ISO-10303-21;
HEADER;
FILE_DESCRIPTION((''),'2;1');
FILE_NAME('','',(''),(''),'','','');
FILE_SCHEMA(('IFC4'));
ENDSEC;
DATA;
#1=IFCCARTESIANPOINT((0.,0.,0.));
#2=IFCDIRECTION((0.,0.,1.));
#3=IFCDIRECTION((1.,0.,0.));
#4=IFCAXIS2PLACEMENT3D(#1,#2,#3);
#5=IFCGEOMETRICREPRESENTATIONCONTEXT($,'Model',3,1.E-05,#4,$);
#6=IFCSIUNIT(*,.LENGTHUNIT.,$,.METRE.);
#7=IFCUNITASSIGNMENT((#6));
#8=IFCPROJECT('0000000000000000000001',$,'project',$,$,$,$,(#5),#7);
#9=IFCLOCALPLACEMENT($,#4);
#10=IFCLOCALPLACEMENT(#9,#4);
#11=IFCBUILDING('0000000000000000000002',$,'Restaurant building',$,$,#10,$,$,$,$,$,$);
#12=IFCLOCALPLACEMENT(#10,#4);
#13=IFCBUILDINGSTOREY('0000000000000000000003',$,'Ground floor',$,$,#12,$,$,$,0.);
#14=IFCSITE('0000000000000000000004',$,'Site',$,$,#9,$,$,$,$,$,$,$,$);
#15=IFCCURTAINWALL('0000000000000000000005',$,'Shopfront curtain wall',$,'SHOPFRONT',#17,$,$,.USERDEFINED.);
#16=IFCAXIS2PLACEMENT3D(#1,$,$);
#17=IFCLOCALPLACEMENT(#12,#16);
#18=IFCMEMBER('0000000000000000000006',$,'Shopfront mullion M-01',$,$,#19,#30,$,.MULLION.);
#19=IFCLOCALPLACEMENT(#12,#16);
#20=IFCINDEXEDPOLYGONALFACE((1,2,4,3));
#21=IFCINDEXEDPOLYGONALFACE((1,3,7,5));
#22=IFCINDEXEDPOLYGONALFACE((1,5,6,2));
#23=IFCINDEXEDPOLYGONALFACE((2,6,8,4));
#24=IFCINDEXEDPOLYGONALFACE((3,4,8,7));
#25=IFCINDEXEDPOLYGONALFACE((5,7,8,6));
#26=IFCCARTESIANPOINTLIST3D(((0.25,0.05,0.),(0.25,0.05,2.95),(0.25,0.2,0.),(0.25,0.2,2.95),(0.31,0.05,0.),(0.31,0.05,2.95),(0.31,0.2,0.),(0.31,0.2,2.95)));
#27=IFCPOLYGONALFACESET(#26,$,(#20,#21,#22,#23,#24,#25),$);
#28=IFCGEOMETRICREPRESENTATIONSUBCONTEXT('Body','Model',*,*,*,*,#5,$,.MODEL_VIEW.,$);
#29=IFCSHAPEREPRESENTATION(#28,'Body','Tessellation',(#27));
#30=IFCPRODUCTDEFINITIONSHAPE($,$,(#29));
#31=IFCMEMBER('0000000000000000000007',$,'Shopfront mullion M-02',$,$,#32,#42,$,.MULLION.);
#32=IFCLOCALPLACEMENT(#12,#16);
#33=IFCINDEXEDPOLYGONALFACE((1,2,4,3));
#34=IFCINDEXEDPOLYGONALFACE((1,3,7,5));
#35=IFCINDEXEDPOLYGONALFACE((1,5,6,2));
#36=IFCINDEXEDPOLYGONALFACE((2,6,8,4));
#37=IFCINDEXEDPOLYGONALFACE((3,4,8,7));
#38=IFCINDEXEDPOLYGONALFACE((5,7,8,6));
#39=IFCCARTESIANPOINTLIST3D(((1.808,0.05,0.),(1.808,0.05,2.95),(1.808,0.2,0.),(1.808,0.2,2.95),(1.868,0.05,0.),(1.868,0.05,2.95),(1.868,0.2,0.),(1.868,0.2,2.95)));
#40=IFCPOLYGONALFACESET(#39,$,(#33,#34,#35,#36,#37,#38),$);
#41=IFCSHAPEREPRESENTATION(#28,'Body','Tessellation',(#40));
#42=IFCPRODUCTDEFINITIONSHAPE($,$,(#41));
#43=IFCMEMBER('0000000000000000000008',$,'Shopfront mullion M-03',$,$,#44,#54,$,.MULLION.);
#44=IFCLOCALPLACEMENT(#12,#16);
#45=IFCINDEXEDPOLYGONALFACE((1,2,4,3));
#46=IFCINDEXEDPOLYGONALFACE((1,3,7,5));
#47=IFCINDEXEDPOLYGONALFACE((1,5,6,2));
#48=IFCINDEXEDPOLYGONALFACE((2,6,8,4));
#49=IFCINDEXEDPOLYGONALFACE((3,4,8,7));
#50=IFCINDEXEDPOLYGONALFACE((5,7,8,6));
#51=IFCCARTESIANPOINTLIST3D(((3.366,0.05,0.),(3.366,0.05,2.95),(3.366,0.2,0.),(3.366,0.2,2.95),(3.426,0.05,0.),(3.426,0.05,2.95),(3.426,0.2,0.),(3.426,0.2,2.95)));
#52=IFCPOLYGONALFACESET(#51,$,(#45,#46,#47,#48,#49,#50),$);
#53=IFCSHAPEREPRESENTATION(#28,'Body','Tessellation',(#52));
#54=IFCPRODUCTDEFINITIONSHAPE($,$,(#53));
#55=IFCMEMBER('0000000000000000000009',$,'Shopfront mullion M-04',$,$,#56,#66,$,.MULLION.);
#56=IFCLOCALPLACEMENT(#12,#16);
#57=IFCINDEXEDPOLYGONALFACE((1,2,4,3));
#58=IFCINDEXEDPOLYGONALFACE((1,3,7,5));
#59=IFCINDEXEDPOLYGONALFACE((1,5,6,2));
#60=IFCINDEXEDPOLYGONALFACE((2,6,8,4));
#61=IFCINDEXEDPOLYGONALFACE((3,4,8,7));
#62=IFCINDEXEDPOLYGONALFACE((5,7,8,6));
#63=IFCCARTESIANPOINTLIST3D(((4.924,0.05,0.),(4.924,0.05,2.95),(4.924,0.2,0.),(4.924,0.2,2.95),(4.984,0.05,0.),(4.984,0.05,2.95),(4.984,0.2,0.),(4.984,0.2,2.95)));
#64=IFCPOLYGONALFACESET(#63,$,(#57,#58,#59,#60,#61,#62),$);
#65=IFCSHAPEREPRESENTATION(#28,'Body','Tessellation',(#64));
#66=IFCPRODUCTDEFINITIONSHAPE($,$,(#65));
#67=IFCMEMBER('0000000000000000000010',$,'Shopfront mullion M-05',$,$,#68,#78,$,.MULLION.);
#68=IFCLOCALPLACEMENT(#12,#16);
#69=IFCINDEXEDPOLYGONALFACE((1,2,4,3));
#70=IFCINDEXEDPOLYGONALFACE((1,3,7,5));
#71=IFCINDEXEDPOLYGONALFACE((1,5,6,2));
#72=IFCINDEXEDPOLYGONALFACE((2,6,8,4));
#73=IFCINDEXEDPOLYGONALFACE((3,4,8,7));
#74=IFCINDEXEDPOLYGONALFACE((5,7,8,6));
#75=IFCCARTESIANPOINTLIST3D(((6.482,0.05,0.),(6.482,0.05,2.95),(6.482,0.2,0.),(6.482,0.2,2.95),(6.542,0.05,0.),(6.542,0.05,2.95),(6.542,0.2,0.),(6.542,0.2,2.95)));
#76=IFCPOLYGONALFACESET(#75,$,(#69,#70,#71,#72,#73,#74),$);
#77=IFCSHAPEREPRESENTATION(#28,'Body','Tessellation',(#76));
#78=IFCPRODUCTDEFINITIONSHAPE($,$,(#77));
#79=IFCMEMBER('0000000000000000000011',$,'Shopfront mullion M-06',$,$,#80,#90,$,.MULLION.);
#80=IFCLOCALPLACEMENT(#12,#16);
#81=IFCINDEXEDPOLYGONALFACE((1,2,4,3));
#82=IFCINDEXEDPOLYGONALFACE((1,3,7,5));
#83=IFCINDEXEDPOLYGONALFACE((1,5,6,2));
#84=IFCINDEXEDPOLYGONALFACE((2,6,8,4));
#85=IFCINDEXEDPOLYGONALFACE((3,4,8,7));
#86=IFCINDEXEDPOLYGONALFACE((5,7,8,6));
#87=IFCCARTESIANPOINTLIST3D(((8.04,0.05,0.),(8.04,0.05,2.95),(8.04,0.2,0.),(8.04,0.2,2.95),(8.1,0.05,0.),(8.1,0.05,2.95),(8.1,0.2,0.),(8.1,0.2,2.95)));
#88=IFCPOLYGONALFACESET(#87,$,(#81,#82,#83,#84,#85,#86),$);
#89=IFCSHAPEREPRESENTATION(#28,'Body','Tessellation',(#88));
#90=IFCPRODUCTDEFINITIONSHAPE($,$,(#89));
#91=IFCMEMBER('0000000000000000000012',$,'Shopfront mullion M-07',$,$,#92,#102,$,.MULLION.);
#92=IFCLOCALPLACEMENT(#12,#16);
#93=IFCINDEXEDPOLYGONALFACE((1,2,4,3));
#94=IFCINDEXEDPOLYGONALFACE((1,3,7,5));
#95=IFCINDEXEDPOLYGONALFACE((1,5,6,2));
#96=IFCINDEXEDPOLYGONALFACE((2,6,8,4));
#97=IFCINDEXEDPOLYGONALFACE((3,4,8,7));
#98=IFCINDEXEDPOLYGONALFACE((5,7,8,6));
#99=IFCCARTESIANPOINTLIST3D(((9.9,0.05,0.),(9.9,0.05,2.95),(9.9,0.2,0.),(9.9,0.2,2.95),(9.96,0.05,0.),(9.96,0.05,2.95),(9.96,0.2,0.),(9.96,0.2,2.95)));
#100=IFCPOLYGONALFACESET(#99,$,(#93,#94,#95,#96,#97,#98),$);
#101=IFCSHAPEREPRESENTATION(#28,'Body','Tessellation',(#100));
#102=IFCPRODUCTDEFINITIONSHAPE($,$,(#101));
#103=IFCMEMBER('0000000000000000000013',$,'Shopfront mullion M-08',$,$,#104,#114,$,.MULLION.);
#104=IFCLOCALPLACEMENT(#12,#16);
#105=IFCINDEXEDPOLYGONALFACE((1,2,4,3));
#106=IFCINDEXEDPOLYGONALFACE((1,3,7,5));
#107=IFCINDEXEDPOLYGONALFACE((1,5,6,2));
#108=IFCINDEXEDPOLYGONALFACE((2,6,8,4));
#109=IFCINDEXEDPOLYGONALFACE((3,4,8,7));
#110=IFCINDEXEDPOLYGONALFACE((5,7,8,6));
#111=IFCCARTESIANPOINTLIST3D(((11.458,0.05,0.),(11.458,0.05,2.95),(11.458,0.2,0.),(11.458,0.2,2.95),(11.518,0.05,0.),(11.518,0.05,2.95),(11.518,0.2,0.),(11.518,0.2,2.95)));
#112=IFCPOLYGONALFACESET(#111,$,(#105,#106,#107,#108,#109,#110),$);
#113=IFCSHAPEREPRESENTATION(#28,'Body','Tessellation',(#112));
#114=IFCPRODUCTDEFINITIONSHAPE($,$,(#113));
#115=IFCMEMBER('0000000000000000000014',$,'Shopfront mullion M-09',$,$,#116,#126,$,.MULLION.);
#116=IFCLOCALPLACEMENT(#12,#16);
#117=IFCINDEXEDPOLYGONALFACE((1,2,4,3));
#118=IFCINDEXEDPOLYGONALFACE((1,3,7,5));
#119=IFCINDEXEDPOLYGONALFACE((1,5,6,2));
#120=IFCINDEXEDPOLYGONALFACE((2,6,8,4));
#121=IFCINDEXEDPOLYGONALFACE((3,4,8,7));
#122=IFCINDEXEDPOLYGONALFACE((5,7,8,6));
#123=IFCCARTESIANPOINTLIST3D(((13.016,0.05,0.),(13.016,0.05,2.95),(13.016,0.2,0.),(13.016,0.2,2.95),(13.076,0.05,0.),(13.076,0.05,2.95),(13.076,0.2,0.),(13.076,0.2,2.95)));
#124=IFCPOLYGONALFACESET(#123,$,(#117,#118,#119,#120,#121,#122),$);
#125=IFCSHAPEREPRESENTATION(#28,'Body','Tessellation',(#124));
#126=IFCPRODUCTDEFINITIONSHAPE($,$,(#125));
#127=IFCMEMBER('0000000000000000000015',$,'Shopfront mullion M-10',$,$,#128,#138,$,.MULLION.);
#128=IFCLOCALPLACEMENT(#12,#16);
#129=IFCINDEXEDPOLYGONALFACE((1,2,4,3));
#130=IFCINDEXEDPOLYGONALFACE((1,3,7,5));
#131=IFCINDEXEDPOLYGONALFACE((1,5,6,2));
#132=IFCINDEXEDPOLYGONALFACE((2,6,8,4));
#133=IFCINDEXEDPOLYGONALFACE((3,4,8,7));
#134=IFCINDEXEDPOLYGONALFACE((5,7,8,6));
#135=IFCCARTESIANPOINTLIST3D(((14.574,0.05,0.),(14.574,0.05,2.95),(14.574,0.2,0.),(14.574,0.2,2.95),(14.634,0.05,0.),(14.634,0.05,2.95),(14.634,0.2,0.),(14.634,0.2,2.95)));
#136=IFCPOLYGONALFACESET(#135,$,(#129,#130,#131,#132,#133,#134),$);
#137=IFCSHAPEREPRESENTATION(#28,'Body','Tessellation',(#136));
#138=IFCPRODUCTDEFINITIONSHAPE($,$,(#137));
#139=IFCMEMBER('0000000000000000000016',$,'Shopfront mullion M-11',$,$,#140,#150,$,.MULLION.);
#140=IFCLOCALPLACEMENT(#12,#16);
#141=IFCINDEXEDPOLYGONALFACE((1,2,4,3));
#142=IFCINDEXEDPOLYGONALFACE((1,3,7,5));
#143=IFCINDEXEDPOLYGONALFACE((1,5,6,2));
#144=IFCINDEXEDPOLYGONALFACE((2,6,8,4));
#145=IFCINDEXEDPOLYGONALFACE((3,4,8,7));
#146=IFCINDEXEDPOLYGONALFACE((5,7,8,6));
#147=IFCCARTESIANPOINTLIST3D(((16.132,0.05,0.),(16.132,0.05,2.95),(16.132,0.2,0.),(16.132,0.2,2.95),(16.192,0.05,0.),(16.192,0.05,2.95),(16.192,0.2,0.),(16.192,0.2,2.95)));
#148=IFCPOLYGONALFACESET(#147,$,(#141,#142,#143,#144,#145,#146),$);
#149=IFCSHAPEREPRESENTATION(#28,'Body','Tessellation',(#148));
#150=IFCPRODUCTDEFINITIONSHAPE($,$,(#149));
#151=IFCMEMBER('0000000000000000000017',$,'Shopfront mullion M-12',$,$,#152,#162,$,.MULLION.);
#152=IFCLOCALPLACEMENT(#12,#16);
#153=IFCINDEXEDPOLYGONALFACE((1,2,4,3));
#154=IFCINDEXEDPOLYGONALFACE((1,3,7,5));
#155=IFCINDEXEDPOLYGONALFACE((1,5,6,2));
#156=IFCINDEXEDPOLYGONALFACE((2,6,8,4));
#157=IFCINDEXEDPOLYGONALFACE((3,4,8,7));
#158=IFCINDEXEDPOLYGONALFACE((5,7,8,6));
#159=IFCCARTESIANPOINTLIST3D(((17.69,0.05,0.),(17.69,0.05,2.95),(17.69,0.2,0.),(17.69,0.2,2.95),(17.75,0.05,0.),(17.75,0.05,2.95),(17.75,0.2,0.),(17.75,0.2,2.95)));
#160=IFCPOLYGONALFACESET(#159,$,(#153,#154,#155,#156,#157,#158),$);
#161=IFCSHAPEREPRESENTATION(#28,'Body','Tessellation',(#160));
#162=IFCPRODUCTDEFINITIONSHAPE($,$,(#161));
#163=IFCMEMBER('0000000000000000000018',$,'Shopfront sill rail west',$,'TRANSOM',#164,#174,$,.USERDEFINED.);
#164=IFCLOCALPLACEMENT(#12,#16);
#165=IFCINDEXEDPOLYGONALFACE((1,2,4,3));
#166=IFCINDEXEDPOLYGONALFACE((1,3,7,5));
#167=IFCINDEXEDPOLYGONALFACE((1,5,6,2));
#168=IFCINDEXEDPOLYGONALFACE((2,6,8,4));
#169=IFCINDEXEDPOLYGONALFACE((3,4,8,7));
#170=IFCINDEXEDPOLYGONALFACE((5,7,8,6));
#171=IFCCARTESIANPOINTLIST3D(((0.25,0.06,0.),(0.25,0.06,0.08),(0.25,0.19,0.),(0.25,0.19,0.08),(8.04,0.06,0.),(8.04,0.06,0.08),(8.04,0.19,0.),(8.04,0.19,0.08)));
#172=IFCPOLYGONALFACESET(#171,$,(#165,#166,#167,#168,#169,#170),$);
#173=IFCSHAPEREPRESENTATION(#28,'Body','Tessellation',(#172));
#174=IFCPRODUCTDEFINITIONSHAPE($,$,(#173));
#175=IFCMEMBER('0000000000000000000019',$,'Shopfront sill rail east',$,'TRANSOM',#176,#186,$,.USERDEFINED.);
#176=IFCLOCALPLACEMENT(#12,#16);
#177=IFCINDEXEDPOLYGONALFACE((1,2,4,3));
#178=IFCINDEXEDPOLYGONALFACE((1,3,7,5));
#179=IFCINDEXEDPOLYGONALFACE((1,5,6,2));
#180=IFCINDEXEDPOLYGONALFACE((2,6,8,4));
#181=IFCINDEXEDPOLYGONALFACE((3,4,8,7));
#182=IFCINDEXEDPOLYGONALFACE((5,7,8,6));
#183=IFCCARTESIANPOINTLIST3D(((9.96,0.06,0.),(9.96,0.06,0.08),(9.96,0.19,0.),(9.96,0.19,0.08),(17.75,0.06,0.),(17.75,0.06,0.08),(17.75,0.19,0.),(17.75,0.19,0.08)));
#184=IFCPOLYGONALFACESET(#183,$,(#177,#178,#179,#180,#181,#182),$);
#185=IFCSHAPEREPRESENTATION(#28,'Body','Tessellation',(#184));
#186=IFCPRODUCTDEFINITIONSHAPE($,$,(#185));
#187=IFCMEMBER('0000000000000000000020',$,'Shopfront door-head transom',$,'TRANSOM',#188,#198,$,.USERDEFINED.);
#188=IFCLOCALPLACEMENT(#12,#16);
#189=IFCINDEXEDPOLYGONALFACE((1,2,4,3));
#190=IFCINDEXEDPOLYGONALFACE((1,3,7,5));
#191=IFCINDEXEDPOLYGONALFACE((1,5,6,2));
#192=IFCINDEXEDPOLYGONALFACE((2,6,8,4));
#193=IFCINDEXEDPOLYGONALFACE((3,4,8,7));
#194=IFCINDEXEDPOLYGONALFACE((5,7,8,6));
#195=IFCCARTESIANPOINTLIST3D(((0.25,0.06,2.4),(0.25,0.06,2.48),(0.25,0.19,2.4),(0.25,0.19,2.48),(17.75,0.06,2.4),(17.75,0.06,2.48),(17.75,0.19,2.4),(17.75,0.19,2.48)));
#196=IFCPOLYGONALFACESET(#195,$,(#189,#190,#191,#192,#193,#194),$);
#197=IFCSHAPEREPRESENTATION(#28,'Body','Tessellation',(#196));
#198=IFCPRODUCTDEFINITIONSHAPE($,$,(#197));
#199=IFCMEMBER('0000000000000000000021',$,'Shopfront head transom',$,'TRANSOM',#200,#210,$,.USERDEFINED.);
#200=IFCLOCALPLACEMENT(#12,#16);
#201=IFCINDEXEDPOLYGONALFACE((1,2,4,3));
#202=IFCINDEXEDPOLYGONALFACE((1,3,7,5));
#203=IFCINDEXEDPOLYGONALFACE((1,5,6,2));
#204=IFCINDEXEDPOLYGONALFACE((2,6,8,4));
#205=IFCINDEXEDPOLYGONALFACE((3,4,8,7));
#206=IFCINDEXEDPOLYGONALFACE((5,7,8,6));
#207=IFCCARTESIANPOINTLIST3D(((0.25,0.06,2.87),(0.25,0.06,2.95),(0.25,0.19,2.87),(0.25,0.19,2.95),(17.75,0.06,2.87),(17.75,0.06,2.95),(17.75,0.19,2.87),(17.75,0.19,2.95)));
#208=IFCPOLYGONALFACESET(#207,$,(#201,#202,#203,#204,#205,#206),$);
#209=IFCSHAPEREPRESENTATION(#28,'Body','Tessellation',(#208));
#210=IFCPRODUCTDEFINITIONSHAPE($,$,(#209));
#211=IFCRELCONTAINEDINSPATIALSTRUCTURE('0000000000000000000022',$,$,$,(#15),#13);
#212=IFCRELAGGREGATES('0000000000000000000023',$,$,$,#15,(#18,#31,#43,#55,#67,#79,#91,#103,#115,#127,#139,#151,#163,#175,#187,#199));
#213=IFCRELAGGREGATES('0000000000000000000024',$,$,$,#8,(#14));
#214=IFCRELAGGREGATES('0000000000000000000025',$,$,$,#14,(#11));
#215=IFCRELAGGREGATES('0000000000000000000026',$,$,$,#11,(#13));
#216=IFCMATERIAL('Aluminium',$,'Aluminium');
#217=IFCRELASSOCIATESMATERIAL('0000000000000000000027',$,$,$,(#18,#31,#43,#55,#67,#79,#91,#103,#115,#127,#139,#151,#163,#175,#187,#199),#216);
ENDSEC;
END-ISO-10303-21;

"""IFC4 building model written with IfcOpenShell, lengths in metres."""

from ifc_helpers import new_model, si_unit, frame, origin, origin_with_axes, origin_2d, place, context, subcontext, project, spatial, rectangle, extrude, material, element, aggregate, save


model = new_model("IFC4")

# Units and contexts
model_context = context("Model", 3, precision=1e-05, world=origin_with_axes())
body_context = subcontext(model_context, "Body", "Model", "MODEL_VIEW")
ifc_project = project(units=[si_unit("LENGTHUNIT", "METRE")], contexts=[model_context])

# Site, building, storey
site_placement = place(None, origin_with_axes())
site = spatial("IfcSite", under=ifc_project, at=site_placement, Name="Site")
building_placement = place(site_placement, origin_with_axes())
building = spatial("IfcBuilding", under=site, at=building_placement, Name="Restaurant building")
storey_placement = place(building_placement, origin_with_axes())
storey = spatial("IfcBuildingStorey", under=building, at=storey_placement, Name="Ground floor", Elevation=0.0)

# Curtain wall, members
curtain_wall_placement = place(storey_placement, origin())
curtain_wall = element("IfcCurtainWall", 1, at=curtain_wall_placement, inside=storey, Name="Shopfront curtain wall", ObjectType="SHOPFRONT", PredefinedType="USERDEFINED")
ifc_material_1 = material(Name="Aluminium", Category="Aluminium")
member_1_placement = place(curtain_wall_placement, origin_with_axes())
member_1 = element("IfcMember", 2, at=member_1_placement, material=ifc_material_1, Name="Shopfront mullion M-01", PredefinedType="MULLION", context=body_context, shape_type="SweptSolid", body=[
    extrude(rectangle(XDim=0.06, YDim=0.15, at=origin_2d()), frame((0.28, 0.125, 0.0)), (0.0, 0.0, 1.0), 2.95),
])
member_2_placement = place(curtain_wall_placement, origin_with_axes())
member_2 = element("IfcMember", 3, at=member_2_placement, material=ifc_material_1, Name="Shopfront mullion M-02", PredefinedType="MULLION", context=body_context, shape_type="SweptSolid", body=[
    extrude(rectangle(XDim=0.06, YDim=0.15, at=origin_2d()), frame((1.838, 0.125, 0.0)), (0.0, 0.0, 1.0), 2.95),
])
member_3_placement = place(curtain_wall_placement, origin_with_axes())
member_3 = element("IfcMember", 4, at=member_3_placement, material=ifc_material_1, Name="Shopfront mullion M-03", PredefinedType="MULLION", context=body_context, shape_type="SweptSolid", body=[
    extrude(rectangle(XDim=0.06, YDim=0.15, at=origin_2d()), frame((3.396, 0.125, 0.0)), (0.0, 0.0, 1.0), 2.95),
])
member_4_placement = place(curtain_wall_placement, origin_with_axes())
member_4 = element("IfcMember", 5, at=member_4_placement, material=ifc_material_1, Name="Shopfront mullion M-04", PredefinedType="MULLION", context=body_context, shape_type="SweptSolid", body=[
    extrude(rectangle(XDim=0.06, YDim=0.15, at=origin_2d()), frame((4.954, 0.125, 0.0)), (0.0, 0.0, 1.0), 2.95),
])
member_5_placement = place(curtain_wall_placement, origin_with_axes())
member_5 = element("IfcMember", 6, at=member_5_placement, material=ifc_material_1, Name="Shopfront mullion M-05", PredefinedType="MULLION", context=body_context, shape_type="SweptSolid", body=[
    extrude(rectangle(XDim=0.06, YDim=0.15, at=origin_2d()), frame((6.512, 0.125, 0.0)), (0.0, 0.0, 1.0), 2.95),
])
member_6_placement = place(curtain_wall_placement, origin_with_axes())
member_6 = element("IfcMember", 7, at=member_6_placement, material=ifc_material_1, Name="Shopfront mullion M-06", PredefinedType="MULLION", context=body_context, shape_type="SweptSolid", body=[
    extrude(rectangle(XDim=0.06, YDim=0.15, at=origin_2d()), frame((8.07, 0.125, 0.0)), (0.0, 0.0, 1.0), 2.95),
])
member_7_placement = place(curtain_wall_placement, origin_with_axes())
member_7 = element("IfcMember", 8, at=member_7_placement, material=ifc_material_1, Name="Shopfront mullion M-07", PredefinedType="MULLION", context=body_context, shape_type="SweptSolid", body=[
    extrude(rectangle(XDim=0.06, YDim=0.15, at=origin_2d()), frame((9.93, 0.125, 0.0)), (0.0, 0.0, 1.0), 2.95),
])
member_8_placement = place(curtain_wall_placement, origin_with_axes())
member_8 = element("IfcMember", 9, at=member_8_placement, material=ifc_material_1, Name="Shopfront mullion M-08", PredefinedType="MULLION", context=body_context, shape_type="SweptSolid", body=[
    extrude(rectangle(XDim=0.06, YDim=0.15, at=origin_2d()), frame((11.488, 0.125, 0.0)), (0.0, 0.0, 1.0), 2.95),
])
member_9_placement = place(curtain_wall_placement, origin_with_axes())
member_9 = element("IfcMember", 10, at=member_9_placement, material=ifc_material_1, Name="Shopfront mullion M-09", PredefinedType="MULLION", context=body_context, shape_type="SweptSolid", body=[
    extrude(rectangle(XDim=0.06, YDim=0.15, at=origin_2d()), frame((13.046, 0.125, 0.0)), (0.0, 0.0, 1.0), 2.95),
])
member_10_placement = place(curtain_wall_placement, origin_with_axes())
member_10 = element("IfcMember", 11, at=member_10_placement, material=ifc_material_1, Name="Shopfront mullion M-10", PredefinedType="MULLION", context=body_context, shape_type="SweptSolid", body=[
    extrude(rectangle(XDim=0.06, YDim=0.15, at=origin_2d()), frame((14.604, 0.125, 0.0)), (0.0, 0.0, 1.0), 2.95),
])
member_11_placement = place(curtain_wall_placement, origin_with_axes())
member_11 = element("IfcMember", 12, at=member_11_placement, material=ifc_material_1, Name="Shopfront mullion M-11", PredefinedType="MULLION", context=body_context, shape_type="SweptSolid", body=[
    extrude(rectangle(XDim=0.06, YDim=0.15, at=origin_2d()), frame((16.162, 0.125, 0.0)), (0.0, 0.0, 1.0), 2.95),
])
member_12_placement = place(curtain_wall_placement, origin_with_axes())
member_12 = element("IfcMember", 13, at=member_12_placement, material=ifc_material_1, Name="Shopfront mullion M-12", PredefinedType="MULLION", context=body_context, shape_type="SweptSolid", body=[
    extrude(rectangle(XDim=0.06, YDim=0.15, at=origin_2d()), frame((17.72, 0.125, 0.0)), (0.0, 0.0, 1.0), 2.95),
])
member_13_placement = place(curtain_wall_placement, origin_with_axes())
member_13 = element("IfcMember", 14, at=member_13_placement, material=ifc_material_1, Name="Shopfront sill rail west", ObjectType="TRANSOM", PredefinedType="USERDEFINED", context=body_context, shape_type="SweptSolid", body=[
    extrude(rectangle(XDim=7.79, YDim=0.13, at=origin_2d()), frame((4.145, 0.125, 0.0)), (0.0, 0.0, 1.0), 0.08),
])
member_14_placement = place(curtain_wall_placement, origin_with_axes())
member_14 = element("IfcMember", 15, at=member_14_placement, material=ifc_material_1, Name="Shopfront sill rail east", ObjectType="TRANSOM", PredefinedType="USERDEFINED", context=body_context, shape_type="SweptSolid", body=[
    extrude(rectangle(XDim=7.79, YDim=0.13, at=origin_2d()), frame((13.855, 0.125, 0.0)), (0.0, 0.0, 1.0), 0.08),
])
member_15_placement = place(curtain_wall_placement, origin_with_axes())
member_15 = element("IfcMember", 16, at=member_15_placement, material=ifc_material_1, Name="Shopfront door-head transom", ObjectType="TRANSOM", PredefinedType="USERDEFINED", context=body_context, shape_type="SweptSolid", body=[
    extrude(rectangle(XDim=17.5, YDim=0.13, at=origin_2d()), frame((9.0, 0.125, 2.4)), (0.0, 0.0, 1.0), 0.08),
])
member_16_placement = place(curtain_wall_placement, origin_with_axes())
member_16 = element("IfcMember", 17, at=member_16_placement, material=ifc_material_1, Name="Shopfront head transom", ObjectType="TRANSOM", PredefinedType="USERDEFINED", context=body_context, shape_type="SweptSolid", body=[
    extrude(rectangle(XDim=17.5, YDim=0.13, at=origin_2d()), frame((9.0, 0.125, 2.87)), (0.0, 0.0, 1.0), 0.08),
])
aggregate(curtain_wall, [member_1, member_2, member_3, member_4, member_5, member_6, member_7, member_8, member_9, member_10, member_11, member_12, member_13, member_14, member_15, member_16])

save(model, "model.ifc")
